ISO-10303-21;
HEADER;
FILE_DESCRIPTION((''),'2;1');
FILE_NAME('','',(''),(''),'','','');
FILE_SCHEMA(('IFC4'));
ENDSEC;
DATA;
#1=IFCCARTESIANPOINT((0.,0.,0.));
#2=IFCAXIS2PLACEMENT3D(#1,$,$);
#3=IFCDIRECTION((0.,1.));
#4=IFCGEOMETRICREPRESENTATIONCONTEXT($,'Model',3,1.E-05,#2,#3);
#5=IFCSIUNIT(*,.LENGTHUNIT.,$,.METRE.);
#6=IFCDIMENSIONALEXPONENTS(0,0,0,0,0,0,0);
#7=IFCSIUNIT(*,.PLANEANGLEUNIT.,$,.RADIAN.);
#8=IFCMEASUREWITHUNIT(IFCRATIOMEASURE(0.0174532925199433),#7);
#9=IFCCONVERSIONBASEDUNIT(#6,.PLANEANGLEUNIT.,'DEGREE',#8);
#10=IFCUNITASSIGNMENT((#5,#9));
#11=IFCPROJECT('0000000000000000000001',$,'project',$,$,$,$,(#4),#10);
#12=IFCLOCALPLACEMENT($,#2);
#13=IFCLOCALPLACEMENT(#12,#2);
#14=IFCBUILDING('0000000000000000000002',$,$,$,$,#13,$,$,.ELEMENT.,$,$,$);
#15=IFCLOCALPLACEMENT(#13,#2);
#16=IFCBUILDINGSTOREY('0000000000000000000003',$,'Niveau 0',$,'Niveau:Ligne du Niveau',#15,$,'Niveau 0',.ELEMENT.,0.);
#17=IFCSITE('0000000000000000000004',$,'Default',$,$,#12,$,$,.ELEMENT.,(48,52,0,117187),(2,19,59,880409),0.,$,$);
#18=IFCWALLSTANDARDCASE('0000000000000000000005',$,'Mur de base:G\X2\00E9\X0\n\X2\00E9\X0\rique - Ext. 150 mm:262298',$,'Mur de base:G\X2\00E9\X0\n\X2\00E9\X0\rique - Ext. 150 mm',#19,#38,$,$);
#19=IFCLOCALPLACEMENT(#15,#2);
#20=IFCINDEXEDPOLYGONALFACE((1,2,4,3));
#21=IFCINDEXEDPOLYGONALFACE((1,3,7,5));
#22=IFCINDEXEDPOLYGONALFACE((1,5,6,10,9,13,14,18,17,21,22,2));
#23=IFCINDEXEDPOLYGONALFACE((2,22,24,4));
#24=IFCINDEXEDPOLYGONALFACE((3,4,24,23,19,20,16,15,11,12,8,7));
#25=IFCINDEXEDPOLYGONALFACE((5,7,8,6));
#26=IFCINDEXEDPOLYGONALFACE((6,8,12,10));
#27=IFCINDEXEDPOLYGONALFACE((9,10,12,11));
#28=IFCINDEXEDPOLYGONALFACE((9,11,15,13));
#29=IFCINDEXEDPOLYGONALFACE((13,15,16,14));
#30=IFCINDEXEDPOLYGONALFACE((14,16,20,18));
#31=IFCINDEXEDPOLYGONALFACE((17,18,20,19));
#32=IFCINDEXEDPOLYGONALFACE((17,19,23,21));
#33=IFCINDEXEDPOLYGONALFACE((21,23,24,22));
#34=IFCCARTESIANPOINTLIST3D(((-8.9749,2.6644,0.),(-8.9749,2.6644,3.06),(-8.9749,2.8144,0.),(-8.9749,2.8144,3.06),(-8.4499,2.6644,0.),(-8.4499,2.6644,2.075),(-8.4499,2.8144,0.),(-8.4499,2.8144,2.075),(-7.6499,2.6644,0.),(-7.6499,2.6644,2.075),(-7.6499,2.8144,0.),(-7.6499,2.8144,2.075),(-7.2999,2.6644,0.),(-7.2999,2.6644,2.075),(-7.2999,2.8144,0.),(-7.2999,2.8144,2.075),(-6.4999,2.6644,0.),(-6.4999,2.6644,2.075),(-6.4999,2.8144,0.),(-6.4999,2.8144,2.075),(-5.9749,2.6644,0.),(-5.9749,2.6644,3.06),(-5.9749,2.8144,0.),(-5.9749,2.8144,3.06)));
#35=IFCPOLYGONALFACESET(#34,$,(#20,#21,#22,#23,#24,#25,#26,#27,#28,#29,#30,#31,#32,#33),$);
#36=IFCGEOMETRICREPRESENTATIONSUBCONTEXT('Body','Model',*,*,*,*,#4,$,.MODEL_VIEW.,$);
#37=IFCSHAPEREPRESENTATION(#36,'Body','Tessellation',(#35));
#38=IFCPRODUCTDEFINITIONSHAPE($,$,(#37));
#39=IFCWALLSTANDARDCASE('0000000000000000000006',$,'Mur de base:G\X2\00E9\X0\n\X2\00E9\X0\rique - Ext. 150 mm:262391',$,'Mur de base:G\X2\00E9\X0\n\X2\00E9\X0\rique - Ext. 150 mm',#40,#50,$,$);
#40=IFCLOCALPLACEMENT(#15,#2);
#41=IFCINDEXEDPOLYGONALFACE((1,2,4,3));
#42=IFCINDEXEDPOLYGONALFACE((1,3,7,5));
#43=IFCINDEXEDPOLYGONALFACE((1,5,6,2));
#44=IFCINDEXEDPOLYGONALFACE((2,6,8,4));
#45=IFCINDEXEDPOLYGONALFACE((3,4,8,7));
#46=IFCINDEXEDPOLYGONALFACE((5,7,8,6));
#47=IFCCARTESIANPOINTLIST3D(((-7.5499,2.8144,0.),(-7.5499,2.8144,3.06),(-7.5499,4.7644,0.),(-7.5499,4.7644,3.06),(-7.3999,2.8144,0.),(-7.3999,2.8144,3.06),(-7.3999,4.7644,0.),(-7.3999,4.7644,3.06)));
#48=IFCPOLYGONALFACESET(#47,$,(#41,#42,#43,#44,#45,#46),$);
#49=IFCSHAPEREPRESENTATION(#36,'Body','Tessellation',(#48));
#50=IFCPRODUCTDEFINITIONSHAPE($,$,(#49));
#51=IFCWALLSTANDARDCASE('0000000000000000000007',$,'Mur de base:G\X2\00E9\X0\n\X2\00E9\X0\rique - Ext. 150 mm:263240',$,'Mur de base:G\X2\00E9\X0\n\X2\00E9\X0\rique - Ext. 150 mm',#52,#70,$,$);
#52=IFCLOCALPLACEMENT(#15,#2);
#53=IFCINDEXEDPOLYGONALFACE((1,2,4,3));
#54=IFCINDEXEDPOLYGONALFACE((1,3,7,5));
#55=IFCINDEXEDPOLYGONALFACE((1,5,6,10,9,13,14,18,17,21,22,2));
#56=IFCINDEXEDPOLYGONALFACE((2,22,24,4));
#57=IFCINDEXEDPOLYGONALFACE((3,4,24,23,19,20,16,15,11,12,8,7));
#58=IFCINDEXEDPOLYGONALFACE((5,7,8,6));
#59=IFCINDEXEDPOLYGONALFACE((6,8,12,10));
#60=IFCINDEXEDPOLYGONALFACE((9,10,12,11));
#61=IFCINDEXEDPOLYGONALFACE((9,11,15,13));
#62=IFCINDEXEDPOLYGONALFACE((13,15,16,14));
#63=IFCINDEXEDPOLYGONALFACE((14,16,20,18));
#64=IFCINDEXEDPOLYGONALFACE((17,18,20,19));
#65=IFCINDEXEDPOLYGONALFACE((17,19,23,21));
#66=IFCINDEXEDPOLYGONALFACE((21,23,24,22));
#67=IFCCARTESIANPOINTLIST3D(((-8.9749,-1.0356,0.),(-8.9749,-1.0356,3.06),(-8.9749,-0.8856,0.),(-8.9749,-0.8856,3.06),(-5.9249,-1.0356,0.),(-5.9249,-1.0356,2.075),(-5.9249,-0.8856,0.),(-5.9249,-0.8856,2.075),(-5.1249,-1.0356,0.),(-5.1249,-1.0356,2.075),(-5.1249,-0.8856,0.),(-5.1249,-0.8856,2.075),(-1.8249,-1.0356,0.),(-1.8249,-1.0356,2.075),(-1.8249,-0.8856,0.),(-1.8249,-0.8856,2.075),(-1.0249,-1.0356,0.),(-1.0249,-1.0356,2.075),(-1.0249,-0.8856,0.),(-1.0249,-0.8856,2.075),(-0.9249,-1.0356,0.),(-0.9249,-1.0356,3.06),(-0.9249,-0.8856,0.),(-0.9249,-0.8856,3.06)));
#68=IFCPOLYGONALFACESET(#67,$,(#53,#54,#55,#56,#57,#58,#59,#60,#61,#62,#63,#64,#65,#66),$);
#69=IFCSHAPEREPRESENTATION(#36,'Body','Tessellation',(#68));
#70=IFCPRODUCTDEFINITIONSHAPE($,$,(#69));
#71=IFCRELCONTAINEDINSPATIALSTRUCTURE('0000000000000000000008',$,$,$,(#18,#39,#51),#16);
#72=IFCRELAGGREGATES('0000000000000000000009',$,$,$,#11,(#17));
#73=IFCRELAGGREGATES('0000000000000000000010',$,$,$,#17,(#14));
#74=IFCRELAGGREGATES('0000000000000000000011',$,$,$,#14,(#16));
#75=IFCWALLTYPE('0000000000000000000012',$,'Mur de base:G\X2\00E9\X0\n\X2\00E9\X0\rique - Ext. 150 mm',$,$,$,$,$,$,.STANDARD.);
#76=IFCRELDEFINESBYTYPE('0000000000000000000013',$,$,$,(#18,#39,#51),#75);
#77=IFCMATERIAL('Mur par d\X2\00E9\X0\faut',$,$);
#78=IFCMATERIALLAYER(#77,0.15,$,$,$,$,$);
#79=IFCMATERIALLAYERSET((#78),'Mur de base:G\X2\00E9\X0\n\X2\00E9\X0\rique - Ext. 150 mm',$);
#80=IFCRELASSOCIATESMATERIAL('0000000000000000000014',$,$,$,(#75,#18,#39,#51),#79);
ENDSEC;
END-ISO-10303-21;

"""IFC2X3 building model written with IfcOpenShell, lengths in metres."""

from ifc_helpers import new_model, entity, si_unit, converted_unit, direction, frame, frame_2d, origin, place, context, subcontext, project, spatial, rectangle, extrude, material, layer, layer_set, layer_usage, type_object, element, save


model = new_model("IFC2X3")

# Units and contexts
model_context = context("Model", 3, precision=1e-05, world=origin(), true_north=direction((0.0, 1.0)))
body_context = subcontext(model_context, "Body", "Model", "MODEL_VIEW")
ifc_project = project(units=[si_unit("LENGTHUNIT", "METRE"), converted_unit("PLANEANGLEUNIT", "DEGREE", entity("IfcRatioMeasure", 0.0174532925199433), si_unit("PLANEANGLEUNIT", "RADIAN"), dimensions=[0, 0, 0, 0, 0, 0, 0])], contexts=[model_context])

# Site, building, storey
site_placement = place(None, origin())
site = spatial("IfcSite", under=ifc_project, at=site_placement, Name="Default", CompositionType="ELEMENT", RefLatitude=(48, 52, 0, 117187), RefLongitude=(2, 19, 59, 880409), RefElevation=0.0)
building_placement = place(site_placement, origin())
building = spatial("IfcBuilding", under=site, at=building_placement, CompositionType="ELEMENT")
storey_placement = place(building_placement, origin())
storey = spatial("IfcBuildingStorey", under=building, at=storey_placement, Name="Niveau 0", ObjectType="Niveau:Ligne du Niveau", LongName="Niveau 0", CompositionType="ELEMENT", Elevation=0.0)

# Shared definitions
ifc_material_1 = material(Name="Mur par défaut")
ifc_layer_1 = layer(ifc_material_1, 0.15)
ifc_layer_set_1 = layer_set([ifc_layer_1], Name="Mur de base:Générique - Ext. 150 mm")
wall_type = type_object("IfcWallType", Name="Mur de base:Générique - Ext. 150 mm", PredefinedType="STANDARD", material=ifc_layer_set_1)

# Wall, openings
ifc_layer_usage_1 = layer_usage(ifc_layer_set_1, "AXIS2", "NEGATIVE", 0.075)
wall_1_placement = place(storey_placement, frame((-8.9749, 2.7394, 0.0)))
wall_1 = element("IfcWallStandardCase", 1, at=wall_1_placement, inside=storey, type_object=wall_type, material=ifc_layer_usage_1, Name="Mur de base:Générique - Ext. 150 mm:262298", ObjectType="Mur de base:Générique - Ext. 150 mm", context=body_context, shape_type="SweptSolid", body=[
    extrude(rectangle(XDim=3.0, YDim=0.15, at=frame_2d((1.5, 0.0), x_axis=(-1.0, 0.0))), origin(), (0.0, 0.0, 1.0), 3.06),
])
opening_1_placement = place(wall_1_placement, frame((0.525, -0.075, 0.0)))
element("IfcOpeningElement", 2, at=opening_1_placement, cuts=wall_1, ObjectType="Opening", context=body_context, shape_type="SweptSolid", body=[
    extrude(rectangle(XDim=2.075, YDim=0.8, at=frame_2d((1.0375, 0.4), x_axis=(1.0, 0.0))), frame((0.0, 0.0, 0.0), z_axis=(0.0, 1.0, 0.0), x_axis=(0.0, 0.0, 1.0)), (0.0, 0.0, 1.0), 0.15),
])
opening_2_placement = place(wall_1_placement, frame((1.675, -0.075, 0.0)))
element("IfcOpeningElement", 3, at=opening_2_placement, cuts=wall_1, ObjectType="Opening", context=body_context, shape_type="SweptSolid", body=[
    extrude(rectangle(XDim=2.075, YDim=0.8, at=frame_2d((1.0375, 0.4), x_axis=(1.0, 0.0))), frame((0.0, 0.0, 0.0), z_axis=(0.0, 1.0, 0.0), x_axis=(0.0, 0.0, 1.0)), (0.0, 0.0, 1.0), 0.15),
])

# Wall
ifc_layer_usage_2 = layer_usage(ifc_layer_set_1, "AXIS2", "NEGATIVE", 0.075)
wall_2_placement = place(storey_placement, frame((-7.4749, 2.8144, 0.0), z_axis=(0.0, 0.0, 1.0), x_axis=(0.0, 1.0, 0.0)))
element("IfcWallStandardCase", 4, at=wall_2_placement, inside=storey, type_object=wall_type, material=ifc_layer_usage_2, Name="Mur de base:Générique - Ext. 150 mm:262391", ObjectType="Mur de base:Générique - Ext. 150 mm", context=body_context, shape_type="SweptSolid", body=[
    extrude(rectangle(XDim=1.95, YDim=0.15, at=frame_2d((0.975, 0.0), x_axis=(-1.0, 0.0))), origin(), (0.0, 0.0, 1.0), 3.06),
])

# Wall, openings
ifc_layer_usage_3 = layer_usage(ifc_layer_set_1, "AXIS2", "NEGATIVE", 0.075)
wall_3_placement = place(storey_placement, frame((-0.9249, -0.9606, 0.0), z_axis=(0.0, 0.0, 1.0), x_axis=(-1.0, 0.0, 0.0)))
wall_3 = element("IfcWallStandardCase", 5, at=wall_3_placement, inside=storey, type_object=wall_type, material=ifc_layer_usage_3, Name="Mur de base:Générique - Ext. 150 mm:263240", ObjectType="Mur de base:Générique - Ext. 150 mm", context=body_context, shape_type="SweptSolid", body=[
    extrude(rectangle(XDim=8.05, YDim=0.15, at=frame_2d((4.025, 0.0), x_axis=(-1.0, 0.0))), origin(), (0.0, 0.0, 1.0), 3.06),
])
opening_3_placement = place(wall_3_placement, frame((4.2, -0.075, 0.0)))
element("IfcOpeningElement", 6, at=opening_3_placement, cuts=wall_3, ObjectType="Opening", context=body_context, shape_type="SweptSolid", body=[
    extrude(rectangle(XDim=2.075, YDim=0.8, at=frame_2d((1.0375, 0.4), x_axis=(1.0, 0.0))), frame((0.0, 0.0, 0.0), z_axis=(0.0, 1.0, 0.0), x_axis=(0.0, 0.0, 1.0)), (0.0, 0.0, 1.0), 0.15),
])
opening_4_placement = place(wall_3_placement, frame((0.1, -0.075, 0.0)))
element("IfcOpeningElement", 7, at=opening_4_placement, cuts=wall_3, ObjectType="Opening", context=body_context, shape_type="SweptSolid", body=[
    extrude(rectangle(XDim=2.075, YDim=0.8, at=frame_2d((1.0375, 0.4), x_axis=(1.0, 0.0))), frame((0.0, 0.0, 0.0), z_axis=(0.0, 1.0, 0.0), x_axis=(0.0, 0.0, 1.0)), (0.0, 0.0, 1.0), 0.15),
])

save(model, "model.ifc")
